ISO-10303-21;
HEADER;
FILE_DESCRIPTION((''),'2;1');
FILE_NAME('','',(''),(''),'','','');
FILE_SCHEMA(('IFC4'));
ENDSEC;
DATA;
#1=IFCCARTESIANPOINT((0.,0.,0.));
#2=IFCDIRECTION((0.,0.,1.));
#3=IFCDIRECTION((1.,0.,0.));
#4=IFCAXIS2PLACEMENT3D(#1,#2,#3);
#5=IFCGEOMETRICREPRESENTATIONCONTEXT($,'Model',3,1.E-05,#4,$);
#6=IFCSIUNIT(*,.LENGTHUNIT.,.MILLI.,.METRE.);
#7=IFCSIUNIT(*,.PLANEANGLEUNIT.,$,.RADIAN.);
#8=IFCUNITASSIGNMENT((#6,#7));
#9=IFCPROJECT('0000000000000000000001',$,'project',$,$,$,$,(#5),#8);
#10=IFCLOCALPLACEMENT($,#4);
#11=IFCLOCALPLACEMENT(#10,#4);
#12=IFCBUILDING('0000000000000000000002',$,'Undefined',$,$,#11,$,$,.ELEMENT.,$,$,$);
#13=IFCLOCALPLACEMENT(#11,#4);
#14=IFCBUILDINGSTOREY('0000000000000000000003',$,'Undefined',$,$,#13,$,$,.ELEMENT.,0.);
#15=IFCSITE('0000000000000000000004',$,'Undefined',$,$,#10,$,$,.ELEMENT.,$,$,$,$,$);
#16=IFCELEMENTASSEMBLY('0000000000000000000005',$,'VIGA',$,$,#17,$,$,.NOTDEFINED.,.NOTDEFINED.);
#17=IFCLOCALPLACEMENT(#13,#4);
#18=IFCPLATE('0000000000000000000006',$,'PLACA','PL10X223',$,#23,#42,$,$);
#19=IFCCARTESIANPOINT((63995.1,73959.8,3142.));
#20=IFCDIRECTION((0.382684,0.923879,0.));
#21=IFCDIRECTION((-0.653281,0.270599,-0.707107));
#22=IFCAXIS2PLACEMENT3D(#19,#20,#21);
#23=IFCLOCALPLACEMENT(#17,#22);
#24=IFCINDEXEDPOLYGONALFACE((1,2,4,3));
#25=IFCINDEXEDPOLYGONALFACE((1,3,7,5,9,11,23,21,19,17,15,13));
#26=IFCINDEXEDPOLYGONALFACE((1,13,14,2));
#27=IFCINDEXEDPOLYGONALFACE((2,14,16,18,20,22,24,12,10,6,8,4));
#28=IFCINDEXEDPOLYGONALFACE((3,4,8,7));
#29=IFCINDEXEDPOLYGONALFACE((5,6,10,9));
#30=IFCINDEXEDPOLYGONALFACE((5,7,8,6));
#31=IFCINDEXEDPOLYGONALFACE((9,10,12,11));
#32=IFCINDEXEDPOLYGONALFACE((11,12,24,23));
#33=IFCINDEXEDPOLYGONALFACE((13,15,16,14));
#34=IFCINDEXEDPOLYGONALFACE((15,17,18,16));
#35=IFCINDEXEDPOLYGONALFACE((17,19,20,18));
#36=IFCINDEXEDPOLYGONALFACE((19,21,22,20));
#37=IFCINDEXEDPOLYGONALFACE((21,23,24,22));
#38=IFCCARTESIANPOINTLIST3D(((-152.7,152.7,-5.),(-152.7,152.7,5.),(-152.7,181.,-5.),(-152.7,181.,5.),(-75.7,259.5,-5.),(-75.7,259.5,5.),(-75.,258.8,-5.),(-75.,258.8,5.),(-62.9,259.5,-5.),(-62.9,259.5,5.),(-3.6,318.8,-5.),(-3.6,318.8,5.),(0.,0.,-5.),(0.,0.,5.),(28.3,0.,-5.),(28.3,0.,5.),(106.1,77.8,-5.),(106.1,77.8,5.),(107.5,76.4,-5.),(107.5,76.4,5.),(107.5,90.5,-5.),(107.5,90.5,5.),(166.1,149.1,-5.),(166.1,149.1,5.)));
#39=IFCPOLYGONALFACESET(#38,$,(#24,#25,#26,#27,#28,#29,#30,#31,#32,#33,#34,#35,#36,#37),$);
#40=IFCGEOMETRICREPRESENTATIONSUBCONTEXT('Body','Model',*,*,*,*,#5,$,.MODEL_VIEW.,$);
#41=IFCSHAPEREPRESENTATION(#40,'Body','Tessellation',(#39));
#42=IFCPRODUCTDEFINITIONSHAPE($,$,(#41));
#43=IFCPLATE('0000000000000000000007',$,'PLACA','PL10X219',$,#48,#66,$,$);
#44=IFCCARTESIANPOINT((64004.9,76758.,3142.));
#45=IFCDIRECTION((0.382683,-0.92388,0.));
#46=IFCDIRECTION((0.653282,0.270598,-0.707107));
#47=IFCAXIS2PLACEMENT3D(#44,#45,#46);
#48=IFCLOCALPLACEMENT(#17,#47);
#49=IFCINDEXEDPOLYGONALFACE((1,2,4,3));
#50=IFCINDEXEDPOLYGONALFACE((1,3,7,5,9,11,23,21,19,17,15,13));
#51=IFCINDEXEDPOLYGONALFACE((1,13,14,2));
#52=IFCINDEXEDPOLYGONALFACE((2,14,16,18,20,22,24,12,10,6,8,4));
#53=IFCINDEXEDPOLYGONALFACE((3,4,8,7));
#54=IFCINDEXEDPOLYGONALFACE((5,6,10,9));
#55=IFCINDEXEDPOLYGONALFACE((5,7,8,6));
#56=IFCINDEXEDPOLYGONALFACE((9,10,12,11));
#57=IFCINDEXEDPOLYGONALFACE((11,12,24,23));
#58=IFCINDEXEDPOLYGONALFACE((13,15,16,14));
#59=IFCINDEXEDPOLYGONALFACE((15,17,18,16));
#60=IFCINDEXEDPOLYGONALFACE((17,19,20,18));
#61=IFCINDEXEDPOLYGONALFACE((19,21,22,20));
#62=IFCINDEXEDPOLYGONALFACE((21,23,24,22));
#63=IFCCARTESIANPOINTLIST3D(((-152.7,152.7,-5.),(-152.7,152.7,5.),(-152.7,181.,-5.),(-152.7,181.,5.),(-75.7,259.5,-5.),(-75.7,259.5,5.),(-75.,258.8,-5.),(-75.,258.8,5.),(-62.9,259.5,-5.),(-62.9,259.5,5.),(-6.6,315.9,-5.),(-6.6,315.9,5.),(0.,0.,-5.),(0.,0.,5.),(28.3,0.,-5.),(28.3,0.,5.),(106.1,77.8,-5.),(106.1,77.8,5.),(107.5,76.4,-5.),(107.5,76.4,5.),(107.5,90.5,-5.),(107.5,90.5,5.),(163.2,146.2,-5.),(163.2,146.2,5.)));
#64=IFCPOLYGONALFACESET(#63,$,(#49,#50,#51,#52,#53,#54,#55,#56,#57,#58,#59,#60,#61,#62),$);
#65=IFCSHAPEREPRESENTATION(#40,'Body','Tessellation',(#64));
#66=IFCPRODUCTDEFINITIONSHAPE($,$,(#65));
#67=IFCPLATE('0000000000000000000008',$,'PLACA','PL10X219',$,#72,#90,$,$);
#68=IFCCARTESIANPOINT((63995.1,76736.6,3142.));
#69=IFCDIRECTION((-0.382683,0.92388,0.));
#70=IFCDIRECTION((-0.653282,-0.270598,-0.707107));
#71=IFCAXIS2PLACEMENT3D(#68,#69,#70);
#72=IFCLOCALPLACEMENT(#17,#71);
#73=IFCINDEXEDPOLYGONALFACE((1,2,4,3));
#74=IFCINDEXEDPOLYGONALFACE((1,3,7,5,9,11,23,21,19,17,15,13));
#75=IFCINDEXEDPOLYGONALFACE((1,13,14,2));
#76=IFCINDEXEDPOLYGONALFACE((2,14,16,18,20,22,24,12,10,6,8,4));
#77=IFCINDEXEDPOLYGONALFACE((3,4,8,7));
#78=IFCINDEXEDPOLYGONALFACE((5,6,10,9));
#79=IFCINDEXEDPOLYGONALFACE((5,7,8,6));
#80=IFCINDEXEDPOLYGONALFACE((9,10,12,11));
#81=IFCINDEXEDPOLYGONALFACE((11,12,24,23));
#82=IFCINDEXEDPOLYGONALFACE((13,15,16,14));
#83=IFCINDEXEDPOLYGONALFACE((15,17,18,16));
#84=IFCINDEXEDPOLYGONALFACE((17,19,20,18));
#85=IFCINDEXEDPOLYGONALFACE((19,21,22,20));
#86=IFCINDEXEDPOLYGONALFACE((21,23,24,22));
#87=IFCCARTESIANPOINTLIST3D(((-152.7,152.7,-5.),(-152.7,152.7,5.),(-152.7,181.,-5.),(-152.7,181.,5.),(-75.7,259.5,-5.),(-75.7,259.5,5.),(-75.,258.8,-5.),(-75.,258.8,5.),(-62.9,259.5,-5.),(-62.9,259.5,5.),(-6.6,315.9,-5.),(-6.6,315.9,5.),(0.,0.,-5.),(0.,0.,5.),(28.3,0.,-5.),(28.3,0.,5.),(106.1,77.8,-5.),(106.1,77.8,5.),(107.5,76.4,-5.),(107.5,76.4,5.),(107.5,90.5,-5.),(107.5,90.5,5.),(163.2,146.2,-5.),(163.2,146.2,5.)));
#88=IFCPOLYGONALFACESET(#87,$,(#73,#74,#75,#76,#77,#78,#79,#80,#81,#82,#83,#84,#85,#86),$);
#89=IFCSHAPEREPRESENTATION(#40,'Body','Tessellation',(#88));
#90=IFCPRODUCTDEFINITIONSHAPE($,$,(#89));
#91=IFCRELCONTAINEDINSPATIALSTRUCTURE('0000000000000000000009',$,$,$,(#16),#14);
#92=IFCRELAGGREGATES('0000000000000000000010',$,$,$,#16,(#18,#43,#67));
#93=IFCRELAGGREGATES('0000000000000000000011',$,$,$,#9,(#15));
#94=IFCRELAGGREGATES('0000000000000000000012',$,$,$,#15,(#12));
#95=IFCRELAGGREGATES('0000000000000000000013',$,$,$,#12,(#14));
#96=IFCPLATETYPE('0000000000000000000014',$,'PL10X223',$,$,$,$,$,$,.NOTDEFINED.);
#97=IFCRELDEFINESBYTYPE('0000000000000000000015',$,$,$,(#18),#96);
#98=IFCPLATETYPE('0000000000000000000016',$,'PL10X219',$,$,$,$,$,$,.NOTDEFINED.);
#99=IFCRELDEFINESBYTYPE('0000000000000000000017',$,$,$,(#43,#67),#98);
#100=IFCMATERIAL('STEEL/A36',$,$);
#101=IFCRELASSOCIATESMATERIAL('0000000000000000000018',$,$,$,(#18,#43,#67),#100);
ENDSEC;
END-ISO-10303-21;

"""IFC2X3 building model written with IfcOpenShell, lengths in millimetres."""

from ifc_helpers import new_model, si_unit, frame, origin_with_axes, place, context, subcontext, project, spatial, polyline, outline, extrude, material, type_object, element, aggregate, save


model = new_model("IFC2X3")

# Units and contexts
model_context = context("Model", 3, precision=1e-05, world=origin_with_axes())
body_context = subcontext(model_context, "Body", "Model", "MODEL_VIEW")
ifc_project = project(units=[si_unit("LENGTHUNIT", "METRE", prefix="MILLI"), si_unit("PLANEANGLEUNIT", "RADIAN")], contexts=[model_context])

# Site, building, storey
site_placement = place(None, origin_with_axes())
site = spatial("IfcSite", under=ifc_project, at=site_placement, Name="Undefined", CompositionType="ELEMENT")
building_placement = place(site_placement, origin_with_axes())
building = spatial("IfcBuilding", under=site, at=building_placement, Name="Undefined", CompositionType="ELEMENT")
storey_placement = place(building_placement, origin_with_axes())
storey = spatial("IfcBuildingStorey", under=building, at=storey_placement, Name="Undefined", CompositionType="ELEMENT", Elevation=0.0)

# Shared definitions
ifc_material_1 = material(Name="STEEL/A36")

# Element assembly, plate
assembly_1_placement = place(storey_placement, origin_with_axes())
assembly_1 = element("IfcElementAssembly", 1, at=assembly_1_placement, inside=storey, Name="VIGA", AssemblyPlace="NOTDEFINED", PredefinedType="NOTDEFINED")
plate_type_1 = type_object("IfcPlateType", Name="PL10X223", PredefinedType="NOTDEFINED")
plate_1_placement = place(assembly_1_placement, frame((63995.1, 73959.8, 3142.0), z_axis=(0.382684, 0.923879, 0.0), x_axis=(-0.653281, 0.270599, -0.707107)))
plate_1 = element("IfcPlate", 2, at=plate_1_placement, type_object=plate_type_1, material=ifc_material_1, Name="PLACA", Description="PL10X223", context=body_context, shape_type="SweptSolid", body=[
    extrude(outline(polyline([(0.0, 0.0), (28.3, 0.0), (106.1, 77.8), (107.5, 76.4), (107.5, 90.5), (166.1, 149.1), (-3.6, 318.8), (-62.9, 259.5), (-75.7, 259.5), (-75.0, 258.8), (-152.7, 181.0), (-152.7, 152.7), (0.0, 0.0)])), frame((0.0, 0.0, -5.0), z_axis=(0.0, 0.0, 1.0), x_axis=(1.0, 0.0, 0.0)), (0.0, 0.0, 1.0), 10.0),
])

# Plates
plate_type_2 = type_object("IfcPlateType", Name="PL10X219", PredefinedType="NOTDEFINED")
plate_2_placement = place(assembly_1_placement, frame((64004.9, 76758.0, 3142.0), z_axis=(0.382683, -0.92388, 0.0), x_axis=(0.653282, 0.270598, -0.707107)))
plate_2 = element("IfcPlate", 3, at=plate_2_placement, type_object=plate_type_2, material=ifc_material_1, Name="PLACA", Description="PL10X219", context=body_context, shape_type="SweptSolid", body=[
    extrude(outline(polyline([(0.0, 0.0), (28.3, 0.0), (106.1, 77.8), (107.5, 76.4), (107.5, 90.5), (163.2, 146.2), (-6.6, 315.9), (-62.9, 259.5), (-75.7, 259.5), (-75.0, 258.8), (-152.7, 181.0), (-152.7, 152.7), (0.0, 0.0)])), frame((0.0, 0.0, -5.0), z_axis=(0.0, 0.0, 1.0), x_axis=(1.0, 0.0, 0.0)), (0.0, 0.0, 1.0), 10.0),
])
plate_3_placement = place(assembly_1_placement, frame((63995.1, 76736.6, 3142.0), z_axis=(-0.382683, 0.92388, 0.0), x_axis=(-0.653282, -0.270598, -0.707107)))
plate_3 = element("IfcPlate", 4, at=plate_3_placement, type_object=plate_type_2, material=ifc_material_1, Name="PLACA", Description="PL10X219", context=body_context, shape_type="SweptSolid", body=[
    extrude(outline(polyline([(0.0, 0.0), (28.3, 0.0), (106.1, 77.8), (107.5, 76.4), (107.5, 90.5), (163.2, 146.2), (-6.6, 315.9), (-62.9, 259.5), (-75.7, 259.5), (-75.0, 258.8), (-152.7, 181.0), (-152.7, 152.7), (0.0, 0.0)])), frame((0.0, 0.0, -5.0), z_axis=(0.0, 0.0, 1.0), x_axis=(1.0, 0.0, 0.0)), (0.0, 0.0, 1.0), 10.0),
])
aggregate(assembly_1, [plate_1, plate_2, plate_3])

save(model, "model.ifc")
